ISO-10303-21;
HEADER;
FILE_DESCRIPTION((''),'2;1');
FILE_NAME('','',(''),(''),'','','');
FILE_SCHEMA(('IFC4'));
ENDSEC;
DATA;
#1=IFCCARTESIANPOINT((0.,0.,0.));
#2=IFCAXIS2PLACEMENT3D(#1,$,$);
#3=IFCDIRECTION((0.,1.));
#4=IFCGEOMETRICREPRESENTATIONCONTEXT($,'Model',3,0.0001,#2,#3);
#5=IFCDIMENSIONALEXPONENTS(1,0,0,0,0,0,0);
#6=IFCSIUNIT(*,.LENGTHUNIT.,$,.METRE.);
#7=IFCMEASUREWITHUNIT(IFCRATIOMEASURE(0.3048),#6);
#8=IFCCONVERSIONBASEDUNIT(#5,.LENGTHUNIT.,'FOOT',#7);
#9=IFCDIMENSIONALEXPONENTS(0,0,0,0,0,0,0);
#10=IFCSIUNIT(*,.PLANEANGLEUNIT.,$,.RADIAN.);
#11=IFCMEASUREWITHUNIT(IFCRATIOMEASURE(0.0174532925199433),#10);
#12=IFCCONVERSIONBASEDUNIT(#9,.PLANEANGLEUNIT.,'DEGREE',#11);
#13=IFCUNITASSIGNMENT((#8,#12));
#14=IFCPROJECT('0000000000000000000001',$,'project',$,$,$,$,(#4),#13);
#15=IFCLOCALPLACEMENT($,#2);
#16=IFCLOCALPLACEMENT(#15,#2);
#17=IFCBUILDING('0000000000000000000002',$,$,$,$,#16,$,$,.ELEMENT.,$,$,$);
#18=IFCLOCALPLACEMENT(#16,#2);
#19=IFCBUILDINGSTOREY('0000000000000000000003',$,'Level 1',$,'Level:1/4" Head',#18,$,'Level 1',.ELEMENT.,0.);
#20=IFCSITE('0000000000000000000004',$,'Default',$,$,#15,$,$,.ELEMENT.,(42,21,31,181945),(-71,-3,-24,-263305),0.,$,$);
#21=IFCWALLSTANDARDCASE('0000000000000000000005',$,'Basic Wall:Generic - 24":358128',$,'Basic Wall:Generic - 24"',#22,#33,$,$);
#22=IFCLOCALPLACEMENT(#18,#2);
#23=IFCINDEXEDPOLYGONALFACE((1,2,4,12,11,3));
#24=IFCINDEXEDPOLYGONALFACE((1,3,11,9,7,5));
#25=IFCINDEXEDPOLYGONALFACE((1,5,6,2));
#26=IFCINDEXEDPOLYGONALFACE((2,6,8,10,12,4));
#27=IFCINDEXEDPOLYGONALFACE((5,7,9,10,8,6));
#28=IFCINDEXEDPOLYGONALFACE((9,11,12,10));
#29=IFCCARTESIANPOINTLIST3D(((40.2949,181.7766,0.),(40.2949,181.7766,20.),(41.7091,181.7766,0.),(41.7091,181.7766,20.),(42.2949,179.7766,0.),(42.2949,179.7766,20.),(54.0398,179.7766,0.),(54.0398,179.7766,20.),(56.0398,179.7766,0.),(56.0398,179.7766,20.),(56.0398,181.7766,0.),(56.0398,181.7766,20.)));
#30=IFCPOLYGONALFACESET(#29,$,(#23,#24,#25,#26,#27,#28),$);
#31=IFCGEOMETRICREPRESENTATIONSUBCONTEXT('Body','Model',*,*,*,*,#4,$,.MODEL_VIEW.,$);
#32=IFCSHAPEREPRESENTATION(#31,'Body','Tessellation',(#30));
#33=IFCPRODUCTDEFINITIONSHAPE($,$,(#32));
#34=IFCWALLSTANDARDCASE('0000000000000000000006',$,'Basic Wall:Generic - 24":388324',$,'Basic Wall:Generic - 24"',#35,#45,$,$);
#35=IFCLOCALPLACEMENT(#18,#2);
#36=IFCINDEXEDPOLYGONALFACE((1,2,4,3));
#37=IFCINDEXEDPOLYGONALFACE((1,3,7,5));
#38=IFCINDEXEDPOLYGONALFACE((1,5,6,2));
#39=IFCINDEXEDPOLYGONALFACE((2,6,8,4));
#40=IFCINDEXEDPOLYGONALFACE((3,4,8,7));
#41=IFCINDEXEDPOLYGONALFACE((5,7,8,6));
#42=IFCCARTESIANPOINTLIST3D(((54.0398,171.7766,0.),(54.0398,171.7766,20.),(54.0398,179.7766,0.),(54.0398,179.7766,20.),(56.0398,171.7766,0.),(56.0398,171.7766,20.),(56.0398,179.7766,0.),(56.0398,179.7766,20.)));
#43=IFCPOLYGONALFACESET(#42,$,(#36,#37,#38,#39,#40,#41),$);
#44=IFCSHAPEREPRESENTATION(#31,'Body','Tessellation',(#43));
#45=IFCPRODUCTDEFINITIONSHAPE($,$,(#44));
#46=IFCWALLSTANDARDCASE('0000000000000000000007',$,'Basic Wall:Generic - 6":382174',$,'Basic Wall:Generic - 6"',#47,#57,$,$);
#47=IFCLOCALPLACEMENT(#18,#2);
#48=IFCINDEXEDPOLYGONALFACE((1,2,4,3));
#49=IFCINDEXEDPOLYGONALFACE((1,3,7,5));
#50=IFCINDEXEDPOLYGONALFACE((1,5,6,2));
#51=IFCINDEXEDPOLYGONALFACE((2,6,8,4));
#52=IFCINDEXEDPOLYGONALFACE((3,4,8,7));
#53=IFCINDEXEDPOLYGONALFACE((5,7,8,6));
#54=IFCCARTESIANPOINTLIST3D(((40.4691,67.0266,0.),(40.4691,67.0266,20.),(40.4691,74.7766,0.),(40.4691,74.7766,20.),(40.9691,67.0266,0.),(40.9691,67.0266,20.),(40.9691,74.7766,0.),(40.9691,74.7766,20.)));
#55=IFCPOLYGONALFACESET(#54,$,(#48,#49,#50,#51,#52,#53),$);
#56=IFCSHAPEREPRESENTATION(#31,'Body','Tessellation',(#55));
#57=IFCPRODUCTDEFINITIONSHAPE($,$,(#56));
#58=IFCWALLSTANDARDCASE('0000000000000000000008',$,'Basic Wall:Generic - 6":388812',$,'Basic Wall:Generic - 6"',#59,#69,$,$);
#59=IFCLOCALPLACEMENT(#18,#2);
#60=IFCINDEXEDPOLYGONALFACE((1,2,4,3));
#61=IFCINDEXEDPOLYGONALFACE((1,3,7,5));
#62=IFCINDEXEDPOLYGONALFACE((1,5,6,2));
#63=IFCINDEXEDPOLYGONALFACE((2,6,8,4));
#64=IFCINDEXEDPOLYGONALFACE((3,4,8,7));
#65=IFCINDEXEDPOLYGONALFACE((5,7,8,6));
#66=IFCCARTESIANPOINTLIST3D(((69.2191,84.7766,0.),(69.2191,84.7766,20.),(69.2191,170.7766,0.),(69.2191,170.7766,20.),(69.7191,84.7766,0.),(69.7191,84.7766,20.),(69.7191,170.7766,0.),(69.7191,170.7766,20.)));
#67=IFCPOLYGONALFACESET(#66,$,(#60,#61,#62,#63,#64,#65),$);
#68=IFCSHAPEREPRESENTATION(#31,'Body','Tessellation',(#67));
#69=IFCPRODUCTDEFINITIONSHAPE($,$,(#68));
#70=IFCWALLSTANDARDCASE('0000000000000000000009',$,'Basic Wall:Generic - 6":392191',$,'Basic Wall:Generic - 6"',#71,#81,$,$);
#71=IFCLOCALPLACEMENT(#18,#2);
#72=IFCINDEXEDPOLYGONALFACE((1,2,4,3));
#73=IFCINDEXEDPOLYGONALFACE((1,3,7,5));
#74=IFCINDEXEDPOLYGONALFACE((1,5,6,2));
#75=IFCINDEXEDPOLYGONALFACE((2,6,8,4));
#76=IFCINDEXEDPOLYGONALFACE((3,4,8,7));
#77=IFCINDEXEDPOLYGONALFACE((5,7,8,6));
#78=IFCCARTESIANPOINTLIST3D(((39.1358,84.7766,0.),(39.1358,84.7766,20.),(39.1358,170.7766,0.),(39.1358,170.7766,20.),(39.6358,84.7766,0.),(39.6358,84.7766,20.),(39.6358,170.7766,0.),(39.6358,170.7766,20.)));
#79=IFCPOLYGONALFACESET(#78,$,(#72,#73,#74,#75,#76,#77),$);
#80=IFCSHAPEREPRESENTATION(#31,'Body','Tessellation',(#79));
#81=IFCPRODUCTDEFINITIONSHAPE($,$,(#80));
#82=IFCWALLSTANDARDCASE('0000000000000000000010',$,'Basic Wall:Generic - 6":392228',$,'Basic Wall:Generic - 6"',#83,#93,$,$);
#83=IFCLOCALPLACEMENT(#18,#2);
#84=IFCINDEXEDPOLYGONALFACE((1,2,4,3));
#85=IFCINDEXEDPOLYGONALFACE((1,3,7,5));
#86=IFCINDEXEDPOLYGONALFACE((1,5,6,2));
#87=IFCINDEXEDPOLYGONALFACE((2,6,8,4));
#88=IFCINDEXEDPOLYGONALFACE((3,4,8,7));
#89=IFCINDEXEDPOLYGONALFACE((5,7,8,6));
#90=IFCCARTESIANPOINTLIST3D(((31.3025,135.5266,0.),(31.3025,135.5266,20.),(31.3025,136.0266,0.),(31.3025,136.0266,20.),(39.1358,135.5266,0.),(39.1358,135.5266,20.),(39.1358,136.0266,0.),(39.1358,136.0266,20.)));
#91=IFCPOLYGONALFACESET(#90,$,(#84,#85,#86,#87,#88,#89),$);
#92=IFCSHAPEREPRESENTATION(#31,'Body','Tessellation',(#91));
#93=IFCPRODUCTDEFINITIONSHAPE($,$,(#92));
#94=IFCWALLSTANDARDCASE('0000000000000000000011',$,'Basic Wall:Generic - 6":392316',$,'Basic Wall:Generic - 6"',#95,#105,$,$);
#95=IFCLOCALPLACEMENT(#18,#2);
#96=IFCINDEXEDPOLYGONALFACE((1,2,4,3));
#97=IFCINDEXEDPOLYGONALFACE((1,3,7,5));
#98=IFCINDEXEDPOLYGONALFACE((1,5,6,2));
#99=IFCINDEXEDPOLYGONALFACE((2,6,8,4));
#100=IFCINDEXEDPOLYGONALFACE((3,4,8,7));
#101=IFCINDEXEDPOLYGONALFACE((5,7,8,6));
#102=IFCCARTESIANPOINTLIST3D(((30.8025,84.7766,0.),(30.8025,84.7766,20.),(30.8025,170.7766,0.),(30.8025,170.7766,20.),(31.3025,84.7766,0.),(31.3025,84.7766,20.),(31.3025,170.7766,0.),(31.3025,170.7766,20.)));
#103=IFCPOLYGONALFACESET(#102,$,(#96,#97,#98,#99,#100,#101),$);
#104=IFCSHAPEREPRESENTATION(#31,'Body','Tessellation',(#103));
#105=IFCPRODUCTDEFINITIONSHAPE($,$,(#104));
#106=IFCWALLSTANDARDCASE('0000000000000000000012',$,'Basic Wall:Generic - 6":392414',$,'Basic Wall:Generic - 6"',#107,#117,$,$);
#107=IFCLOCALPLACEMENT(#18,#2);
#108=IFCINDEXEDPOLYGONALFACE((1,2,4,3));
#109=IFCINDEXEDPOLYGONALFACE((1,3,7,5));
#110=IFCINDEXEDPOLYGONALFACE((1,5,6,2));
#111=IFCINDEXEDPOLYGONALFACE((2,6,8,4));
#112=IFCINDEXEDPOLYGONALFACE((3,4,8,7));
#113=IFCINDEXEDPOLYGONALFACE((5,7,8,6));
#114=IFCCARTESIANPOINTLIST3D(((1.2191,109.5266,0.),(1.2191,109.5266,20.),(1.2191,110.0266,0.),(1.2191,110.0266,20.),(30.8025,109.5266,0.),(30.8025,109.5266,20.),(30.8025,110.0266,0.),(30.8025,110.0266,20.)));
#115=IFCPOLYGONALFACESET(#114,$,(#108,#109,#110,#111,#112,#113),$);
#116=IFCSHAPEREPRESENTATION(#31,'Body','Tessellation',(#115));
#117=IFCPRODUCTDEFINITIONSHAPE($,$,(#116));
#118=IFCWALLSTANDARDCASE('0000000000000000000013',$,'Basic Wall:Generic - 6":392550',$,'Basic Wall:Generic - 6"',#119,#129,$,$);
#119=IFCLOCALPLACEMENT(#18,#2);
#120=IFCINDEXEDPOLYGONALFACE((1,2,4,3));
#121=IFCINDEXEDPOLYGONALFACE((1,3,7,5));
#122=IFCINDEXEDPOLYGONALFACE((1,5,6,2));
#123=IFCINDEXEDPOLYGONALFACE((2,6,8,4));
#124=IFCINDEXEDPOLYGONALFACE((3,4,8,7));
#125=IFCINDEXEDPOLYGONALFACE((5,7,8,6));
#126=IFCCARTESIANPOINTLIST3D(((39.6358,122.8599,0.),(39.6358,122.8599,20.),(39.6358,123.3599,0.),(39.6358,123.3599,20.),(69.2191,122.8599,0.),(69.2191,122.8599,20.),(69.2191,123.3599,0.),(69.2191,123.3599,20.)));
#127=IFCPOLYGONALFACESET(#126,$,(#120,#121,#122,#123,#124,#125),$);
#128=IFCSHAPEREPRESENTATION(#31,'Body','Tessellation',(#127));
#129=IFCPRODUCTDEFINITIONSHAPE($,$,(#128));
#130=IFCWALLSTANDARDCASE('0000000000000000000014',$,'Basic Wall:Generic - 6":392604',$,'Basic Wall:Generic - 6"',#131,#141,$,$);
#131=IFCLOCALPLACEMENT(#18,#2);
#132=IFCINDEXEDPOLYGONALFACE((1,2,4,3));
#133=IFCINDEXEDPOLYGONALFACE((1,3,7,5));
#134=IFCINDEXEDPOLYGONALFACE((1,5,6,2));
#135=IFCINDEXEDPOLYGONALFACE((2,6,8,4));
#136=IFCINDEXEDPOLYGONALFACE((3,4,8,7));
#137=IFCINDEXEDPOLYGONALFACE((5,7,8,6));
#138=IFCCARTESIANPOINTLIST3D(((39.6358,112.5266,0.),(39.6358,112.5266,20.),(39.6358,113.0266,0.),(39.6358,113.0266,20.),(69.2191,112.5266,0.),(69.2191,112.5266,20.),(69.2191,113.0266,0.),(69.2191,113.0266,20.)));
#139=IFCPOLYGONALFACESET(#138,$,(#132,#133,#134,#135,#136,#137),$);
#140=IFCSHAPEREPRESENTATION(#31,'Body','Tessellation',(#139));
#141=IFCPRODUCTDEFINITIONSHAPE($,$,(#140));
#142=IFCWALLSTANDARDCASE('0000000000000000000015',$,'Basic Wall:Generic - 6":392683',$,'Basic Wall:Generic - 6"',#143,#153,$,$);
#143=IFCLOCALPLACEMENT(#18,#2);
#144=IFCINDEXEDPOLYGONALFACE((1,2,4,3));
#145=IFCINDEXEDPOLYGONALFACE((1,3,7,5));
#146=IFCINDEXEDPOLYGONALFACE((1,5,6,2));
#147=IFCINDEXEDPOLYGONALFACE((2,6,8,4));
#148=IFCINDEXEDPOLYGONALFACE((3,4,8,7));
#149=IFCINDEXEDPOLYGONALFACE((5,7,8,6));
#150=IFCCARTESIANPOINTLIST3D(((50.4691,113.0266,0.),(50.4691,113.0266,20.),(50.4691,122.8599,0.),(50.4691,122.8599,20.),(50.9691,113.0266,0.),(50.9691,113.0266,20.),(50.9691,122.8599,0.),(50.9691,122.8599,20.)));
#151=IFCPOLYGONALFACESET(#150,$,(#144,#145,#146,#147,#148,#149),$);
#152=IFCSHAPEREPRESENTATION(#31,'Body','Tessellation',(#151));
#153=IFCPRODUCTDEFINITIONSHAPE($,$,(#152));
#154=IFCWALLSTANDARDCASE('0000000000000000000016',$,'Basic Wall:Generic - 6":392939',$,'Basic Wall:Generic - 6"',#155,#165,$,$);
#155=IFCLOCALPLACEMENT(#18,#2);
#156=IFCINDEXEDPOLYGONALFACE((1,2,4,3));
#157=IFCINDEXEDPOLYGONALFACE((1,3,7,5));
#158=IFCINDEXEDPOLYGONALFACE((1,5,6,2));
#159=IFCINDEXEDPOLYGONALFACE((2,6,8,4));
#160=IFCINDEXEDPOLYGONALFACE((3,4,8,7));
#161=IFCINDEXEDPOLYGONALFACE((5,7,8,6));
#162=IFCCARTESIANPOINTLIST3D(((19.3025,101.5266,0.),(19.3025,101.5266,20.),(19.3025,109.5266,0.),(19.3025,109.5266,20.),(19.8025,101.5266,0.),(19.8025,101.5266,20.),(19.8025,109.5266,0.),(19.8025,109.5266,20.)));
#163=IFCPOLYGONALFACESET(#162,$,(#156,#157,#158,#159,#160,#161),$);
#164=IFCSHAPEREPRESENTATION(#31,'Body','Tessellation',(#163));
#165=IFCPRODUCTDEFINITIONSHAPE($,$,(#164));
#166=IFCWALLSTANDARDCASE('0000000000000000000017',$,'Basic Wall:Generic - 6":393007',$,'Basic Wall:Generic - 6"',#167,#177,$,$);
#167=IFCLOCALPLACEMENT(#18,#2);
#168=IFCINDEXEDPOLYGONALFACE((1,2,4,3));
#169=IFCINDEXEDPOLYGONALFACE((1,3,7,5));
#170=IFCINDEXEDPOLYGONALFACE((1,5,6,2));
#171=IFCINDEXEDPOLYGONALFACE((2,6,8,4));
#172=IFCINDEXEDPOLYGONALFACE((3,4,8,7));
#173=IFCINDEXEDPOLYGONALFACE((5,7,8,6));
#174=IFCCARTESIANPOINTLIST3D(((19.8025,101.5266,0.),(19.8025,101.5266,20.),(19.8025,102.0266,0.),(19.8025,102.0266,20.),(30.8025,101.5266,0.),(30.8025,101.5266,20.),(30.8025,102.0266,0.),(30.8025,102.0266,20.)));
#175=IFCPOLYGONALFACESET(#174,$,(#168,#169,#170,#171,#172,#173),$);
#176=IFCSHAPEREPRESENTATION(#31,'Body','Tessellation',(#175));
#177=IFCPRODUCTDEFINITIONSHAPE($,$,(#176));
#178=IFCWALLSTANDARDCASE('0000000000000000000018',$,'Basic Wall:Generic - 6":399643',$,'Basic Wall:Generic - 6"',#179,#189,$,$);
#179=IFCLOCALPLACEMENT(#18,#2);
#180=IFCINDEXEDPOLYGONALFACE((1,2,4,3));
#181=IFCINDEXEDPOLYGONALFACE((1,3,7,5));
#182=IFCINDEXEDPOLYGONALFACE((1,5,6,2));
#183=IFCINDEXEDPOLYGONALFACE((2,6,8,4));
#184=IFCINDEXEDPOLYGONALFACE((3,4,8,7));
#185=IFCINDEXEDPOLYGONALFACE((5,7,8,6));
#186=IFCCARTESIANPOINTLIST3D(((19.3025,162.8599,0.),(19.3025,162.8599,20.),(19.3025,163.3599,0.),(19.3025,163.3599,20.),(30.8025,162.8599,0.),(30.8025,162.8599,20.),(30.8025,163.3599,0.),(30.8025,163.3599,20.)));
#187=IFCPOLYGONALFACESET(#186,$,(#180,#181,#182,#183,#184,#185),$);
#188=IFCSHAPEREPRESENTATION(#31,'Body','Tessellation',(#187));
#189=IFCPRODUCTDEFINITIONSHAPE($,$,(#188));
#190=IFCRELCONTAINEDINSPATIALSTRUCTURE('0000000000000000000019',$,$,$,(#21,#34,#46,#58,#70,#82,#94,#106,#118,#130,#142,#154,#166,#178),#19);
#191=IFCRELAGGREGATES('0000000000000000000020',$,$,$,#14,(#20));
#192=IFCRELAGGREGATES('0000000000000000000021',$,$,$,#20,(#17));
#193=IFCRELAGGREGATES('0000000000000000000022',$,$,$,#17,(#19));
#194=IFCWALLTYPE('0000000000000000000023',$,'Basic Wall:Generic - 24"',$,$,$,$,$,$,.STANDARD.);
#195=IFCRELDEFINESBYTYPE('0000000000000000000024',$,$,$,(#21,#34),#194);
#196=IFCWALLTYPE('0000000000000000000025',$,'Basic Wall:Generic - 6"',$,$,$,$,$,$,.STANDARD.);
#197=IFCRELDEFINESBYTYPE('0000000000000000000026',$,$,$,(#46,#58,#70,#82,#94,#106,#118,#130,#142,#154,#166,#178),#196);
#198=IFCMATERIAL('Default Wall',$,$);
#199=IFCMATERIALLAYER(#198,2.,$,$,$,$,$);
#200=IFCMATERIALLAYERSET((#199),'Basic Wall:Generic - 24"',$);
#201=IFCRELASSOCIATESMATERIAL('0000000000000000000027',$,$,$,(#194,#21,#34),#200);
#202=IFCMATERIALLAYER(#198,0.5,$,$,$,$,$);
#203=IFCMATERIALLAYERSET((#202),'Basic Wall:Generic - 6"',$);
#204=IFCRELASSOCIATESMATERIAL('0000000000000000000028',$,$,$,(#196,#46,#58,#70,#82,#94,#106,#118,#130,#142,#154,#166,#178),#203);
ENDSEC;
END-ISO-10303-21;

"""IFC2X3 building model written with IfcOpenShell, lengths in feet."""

from ifc_helpers import new_model, entity, si_unit, converted_unit, direction, frame, frame_2d, origin, place, context, subcontext, project, spatial, polyline, rectangle, outline, extrude, material, layer, layer_set, layer_usage, type_object, element, save


model = new_model("IFC2X3")

# Units and contexts
model_context = context("Model", 3, precision=0.0001, world=origin(), true_north=direction((0.0, 1.0)))
body_context = subcontext(model_context, "Body", "Model", "MODEL_VIEW")
ifc_project = project(units=[converted_unit("LENGTHUNIT", "FOOT", entity("IfcRatioMeasure", 0.3048), si_unit("LENGTHUNIT", "METRE"), dimensions=[1, 0, 0, 0, 0, 0, 0]), converted_unit("PLANEANGLEUNIT", "DEGREE", entity("IfcRatioMeasure", 0.0174532925199433), si_unit("PLANEANGLEUNIT", "RADIAN"), dimensions=[0, 0, 0, 0, 0, 0, 0])], contexts=[model_context])

# Site, building, storey
site_placement = place(None, origin())
site = spatial("IfcSite", under=ifc_project, at=site_placement, Name="Default", CompositionType="ELEMENT", RefLatitude=(42, 21, 31, 181945), RefLongitude=(-71, -3, -24, -263305), RefElevation=0.0)
building_placement = place(site_placement, origin())
building = spatial("IfcBuilding", under=site, at=building_placement, CompositionType="ELEMENT")
storey_placement = place(building_placement, origin())
storey = spatial("IfcBuildingStorey", under=building, at=storey_placement, Name="Level 1", ObjectType="Level:1/4\" Head", LongName="Level 1", CompositionType="ELEMENT", Elevation=0.0)

# Walls
ifc_material = material(Name="Default Wall")
ifc_layer_1 = layer(ifc_material, 2.0)
ifc_layer_set_1 = layer_set([ifc_layer_1], Name="Basic Wall:Generic - 24\"")
ifc_layer_usage_1 = layer_usage(ifc_layer_set_1, "AXIS2", "NEGATIVE", 1.0)
wall_type_1 = type_object("IfcWallType", Name="Basic Wall:Generic - 24\"", PredefinedType="STANDARD", material=ifc_layer_set_1)
wall_1_placement = place(storey_placement, frame((40.2949, 180.7766, 0.0)))
element("IfcWallStandardCase", 1, at=wall_1_placement, inside=storey, type_object=wall_type_1, material=ifc_layer_usage_1, Name="Basic Wall:Generic - 24\":358128", ObjectType="Basic Wall:Generic - 24\"", context=body_context, shape_type="SweptSolid", body=[
    extrude(outline(polyline([(15.7449, -1.0), (15.7449, 1.0), (1.4142, 1.0), (0.0, 1.0), (2.0, -1.0), (13.7449, -1.0), (15.7449, -1.0)])), origin(), (0.0, 0.0, 1.0), 20.0),
])
ifc_layer_usage_2 = layer_usage(ifc_layer_set_1, "AXIS2", "NEGATIVE", 1.0)
wall_2_placement = place(storey_placement, frame((55.0398, 179.7766, 0.0), z_axis=(0.0, 0.0, 1.0), x_axis=(0.0, -1.0, 0.0)))
element("IfcWallStandardCase", 2, at=wall_2_placement, inside=storey, type_object=wall_type_1, material=ifc_layer_usage_2, Name="Basic Wall:Generic - 24\":388324", ObjectType="Basic Wall:Generic - 24\"", context=body_context, shape_type="SweptSolid", body=[
    extrude(rectangle(XDim=8.0, YDim=2.0, at=frame_2d((4.0, 0.0), x_axis=(-1.0, 0.0))), origin(), (0.0, 0.0, 1.0), 20.0),
])
ifc_layer_2 = layer(ifc_material, 0.5)
ifc_layer_set_2 = layer_set([ifc_layer_2], Name="Basic Wall:Generic - 6\"")
ifc_layer_usage_3 = layer_usage(ifc_layer_set_2, "AXIS2", "NEGATIVE", 0.25)
wall_type_2 = type_object("IfcWallType", Name="Basic Wall:Generic - 6\"", PredefinedType="STANDARD", material=ifc_layer_set_2)
wall_3_placement = place(storey_placement, frame((40.7191, 74.7766, 0.0), z_axis=(0.0, 0.0, 1.0), x_axis=(0.0, -1.0, 0.0)))
element("IfcWallStandardCase", 3, at=wall_3_placement, inside=storey, type_object=wall_type_2, material=ifc_layer_usage_3, Name="Basic Wall:Generic - 6\":382174", ObjectType="Basic Wall:Generic - 6\"", context=body_context, shape_type="SweptSolid", body=[
    extrude(rectangle(XDim=7.75, YDim=0.5, at=frame_2d((3.875, 0.0), x_axis=(-1.0, 0.0))), origin(), (0.0, 0.0, 1.0), 20.0),
])
ifc_layer_usage_4 = layer_usage(ifc_layer_set_2, "AXIS2", "NEGATIVE", 0.25)
wall_4_placement = place(storey_placement, frame((69.4691, 84.7766, 0.0), z_axis=(0.0, 0.0, 1.0), x_axis=(0.0, 1.0, 0.0)))
element("IfcWallStandardCase", 4, at=wall_4_placement, inside=storey, type_object=wall_type_2, material=ifc_layer_usage_4, Name="Basic Wall:Generic - 6\":388812", ObjectType="Basic Wall:Generic - 6\"", context=body_context, shape_type="SweptSolid", body=[
    extrude(rectangle(XDim=86.0, YDim=0.5, at=frame_2d((43.0, 0.0), x_axis=(-1.0, 0.0))), origin(), (0.0, 0.0, 1.0), 20.0),
])
ifc_layer_usage_5 = layer_usage(ifc_layer_set_2, "AXIS2", "NEGATIVE", 0.25)
wall_5_placement = place(storey_placement, frame((39.3858, 84.7766, 0.0), z_axis=(0.0, 0.0, 1.0), x_axis=(0.0, 1.0, 0.0)))
element("IfcWallStandardCase", 5, at=wall_5_placement, inside=storey, type_object=wall_type_2, material=ifc_layer_usage_5, Name="Basic Wall:Generic - 6\":392191", ObjectType="Basic Wall:Generic - 6\"", context=body_context, shape_type="SweptSolid", body=[
    extrude(rectangle(XDim=86.0, YDim=0.5, at=frame_2d((43.0, 0.0), x_axis=(-1.0, 0.0))), origin(), (0.0, 0.0, 1.0), 20.0),
])
ifc_layer_usage_6 = layer_usage(ifc_layer_set_2, "AXIS2", "NEGATIVE", 0.25)
wall_6_placement = place(storey_placement, frame((39.1358, 135.7766, 0.0), z_axis=(0.0, 0.0, 1.0), x_axis=(-1.0, 0.0, 0.0)))
element("IfcWallStandardCase", 6, at=wall_6_placement, inside=storey, type_object=wall_type_2, material=ifc_layer_usage_6, Name="Basic Wall:Generic - 6\":392228", ObjectType="Basic Wall:Generic - 6\"", context=body_context, shape_type="SweptSolid", body=[
    extrude(rectangle(XDim=7.8333, YDim=0.5, at=frame_2d((3.9167, 0.0), x_axis=(-1.0, 0.0))), origin(), (0.0, 0.0, 1.0), 20.0),
])
ifc_layer_usage_7 = layer_usage(ifc_layer_set_2, "AXIS2", "NEGATIVE", 0.25)
wall_7_placement = place(storey_placement, frame((31.0525, 170.7766, 0.0), z_axis=(0.0, 0.0, 1.0), x_axis=(0.0, -1.0, 0.0)))
element("IfcWallStandardCase", 7, at=wall_7_placement, inside=storey, type_object=wall_type_2, material=ifc_layer_usage_7, Name="Basic Wall:Generic - 6\":392316", ObjectType="Basic Wall:Generic - 6\"", context=body_context, shape_type="SweptSolid", body=[
    extrude(rectangle(XDim=86.0, YDim=0.5, at=frame_2d((43.0, 0.0), x_axis=(-1.0, 0.0))), origin(), (0.0, 0.0, 1.0), 20.0),
])
ifc_layer_usage_8 = layer_usage(ifc_layer_set_2, "AXIS2", "NEGATIVE", 0.25)
wall_8_placement = place(storey_placement, frame((30.8025, 109.7766, 0.0), z_axis=(0.0, 0.0, 1.0), x_axis=(-1.0, 0.0, 0.0)))
element("IfcWallStandardCase", 8, at=wall_8_placement, inside=storey, type_object=wall_type_2, material=ifc_layer_usage_8, Name="Basic Wall:Generic - 6\":392414", ObjectType="Basic Wall:Generic - 6\"", context=body_context, shape_type="SweptSolid", body=[
    extrude(rectangle(XDim=29.5833, YDim=0.5, at=frame_2d((14.7917, 0.0), x_axis=(-1.0, 0.0))), origin(), (0.0, 0.0, 1.0), 20.0),
])
ifc_layer_usage_9 = layer_usage(ifc_layer_set_2, "AXIS2", "NEGATIVE", 0.25)
wall_9_placement = place(storey_placement, frame((39.6358, 123.1099, 0.0)))
element("IfcWallStandardCase", 9, at=wall_9_placement, inside=storey, type_object=wall_type_2, material=ifc_layer_usage_9, Name="Basic Wall:Generic - 6\":392550", ObjectType="Basic Wall:Generic - 6\"", context=body_context, shape_type="SweptSolid", body=[
    extrude(rectangle(XDim=29.5833, YDim=0.5, at=frame_2d((14.7917, 0.0), x_axis=(-1.0, 0.0))), origin(), (0.0, 0.0, 1.0), 20.0),
])
ifc_layer_usage_10 = layer_usage(ifc_layer_set_2, "AXIS2", "NEGATIVE", 0.25)
wall_10_placement = place(storey_placement, frame((39.6358, 112.7766, 0.0)))
element("IfcWallStandardCase", 10, at=wall_10_placement, inside=storey, type_object=wall_type_2, material=ifc_layer_usage_10, Name="Basic Wall:Generic - 6\":392604", ObjectType="Basic Wall:Generic - 6\"", context=body_context, shape_type="SweptSolid", body=[
    extrude(rectangle(XDim=29.5833, YDim=0.5, at=frame_2d((14.7917, 0.0), x_axis=(-1.0, 0.0))), origin(), (0.0, 0.0, 1.0), 20.0),
])
ifc_layer_usage_11 = layer_usage(ifc_layer_set_2, "AXIS2", "NEGATIVE", 0.25)
wall_11_placement = place(storey_placement, frame((50.7191, 122.8599, 0.0), z_axis=(0.0, 0.0, 1.0), x_axis=(0.0, -1.0, 0.0)))
element("IfcWallStandardCase", 11, at=wall_11_placement, inside=storey, type_object=wall_type_2, material=ifc_layer_usage_11, Name="Basic Wall:Generic - 6\":392683", ObjectType="Basic Wall:Generic - 6\"", context=body_context, shape_type="SweptSolid", body=[
    extrude(rectangle(XDim=9.8333, YDim=0.5, at=frame_2d((4.9167, 0.0), x_axis=(-1.0, 0.0))), origin(), (0.0, 0.0, 1.0), 20.0),
])
ifc_layer_usage_12 = layer_usage(ifc_layer_set_2, "AXIS2", "NEGATIVE", 0.25)
wall_12_placement = place(storey_placement, frame((19.5525, 109.5266, 0.0), z_axis=(0.0, 0.0, 1.0), x_axis=(0.0, -1.0, 0.0)))
element("IfcWallStandardCase", 12, at=wall_12_placement, inside=storey, type_object=wall_type_2, material=ifc_layer_usage_12, Name="Basic Wall:Generic - 6\":392939", ObjectType="Basic Wall:Generic - 6\"", context=body_context, shape_type="SweptSolid", body=[
    extrude(rectangle(XDim=8.0, YDim=0.5, at=frame_2d((4.0, 0.0), x_axis=(-1.0, 0.0))), origin(), (0.0, 0.0, 1.0), 20.0),
])
ifc_layer_usage_13 = layer_usage(ifc_layer_set_2, "AXIS2", "NEGATIVE", 0.25)
wall_13_placement = place(storey_placement, frame((19.8025, 101.7766, 0.0)))
element("IfcWallStandardCase", 13, at=wall_13_placement, inside=storey, type_object=wall_type_2, material=ifc_layer_usage_13, Name="Basic Wall:Generic - 6\":393007", ObjectType="Basic Wall:Generic - 6\"", context=body_context, shape_type="SweptSolid", body=[
    extrude(rectangle(XDim=11.0, YDim=0.5, at=frame_2d((5.5, 0.0), x_axis=(-1.0, 0.0))), origin(), (0.0, 0.0, 1.0), 20.0),
])
ifc_layer_usage_14 = layer_usage(ifc_layer_set_2, "AXIS2", "NEGATIVE", 0.25)
wall_14_placement = place(storey_placement, frame((30.8025, 163.1099, 0.0), z_axis=(0.0, 0.0, 1.0), x_axis=(-1.0, 0.0, 0.0)))
element("IfcWallStandardCase", 14, at=wall_14_placement, inside=storey, type_object=wall_type_2, material=ifc_layer_usage_14, Name="Basic Wall:Generic - 6\":399643", ObjectType="Basic Wall:Generic - 6\"", context=body_context, shape_type="SweptSolid", body=[
    extrude(rectangle(XDim=11.5, YDim=0.5, at=frame_2d((5.75, 0.0), x_axis=(-1.0, 0.0))), origin(), (0.0, 0.0, 1.0), 20.0),
])

save(model, "model.ifc")
